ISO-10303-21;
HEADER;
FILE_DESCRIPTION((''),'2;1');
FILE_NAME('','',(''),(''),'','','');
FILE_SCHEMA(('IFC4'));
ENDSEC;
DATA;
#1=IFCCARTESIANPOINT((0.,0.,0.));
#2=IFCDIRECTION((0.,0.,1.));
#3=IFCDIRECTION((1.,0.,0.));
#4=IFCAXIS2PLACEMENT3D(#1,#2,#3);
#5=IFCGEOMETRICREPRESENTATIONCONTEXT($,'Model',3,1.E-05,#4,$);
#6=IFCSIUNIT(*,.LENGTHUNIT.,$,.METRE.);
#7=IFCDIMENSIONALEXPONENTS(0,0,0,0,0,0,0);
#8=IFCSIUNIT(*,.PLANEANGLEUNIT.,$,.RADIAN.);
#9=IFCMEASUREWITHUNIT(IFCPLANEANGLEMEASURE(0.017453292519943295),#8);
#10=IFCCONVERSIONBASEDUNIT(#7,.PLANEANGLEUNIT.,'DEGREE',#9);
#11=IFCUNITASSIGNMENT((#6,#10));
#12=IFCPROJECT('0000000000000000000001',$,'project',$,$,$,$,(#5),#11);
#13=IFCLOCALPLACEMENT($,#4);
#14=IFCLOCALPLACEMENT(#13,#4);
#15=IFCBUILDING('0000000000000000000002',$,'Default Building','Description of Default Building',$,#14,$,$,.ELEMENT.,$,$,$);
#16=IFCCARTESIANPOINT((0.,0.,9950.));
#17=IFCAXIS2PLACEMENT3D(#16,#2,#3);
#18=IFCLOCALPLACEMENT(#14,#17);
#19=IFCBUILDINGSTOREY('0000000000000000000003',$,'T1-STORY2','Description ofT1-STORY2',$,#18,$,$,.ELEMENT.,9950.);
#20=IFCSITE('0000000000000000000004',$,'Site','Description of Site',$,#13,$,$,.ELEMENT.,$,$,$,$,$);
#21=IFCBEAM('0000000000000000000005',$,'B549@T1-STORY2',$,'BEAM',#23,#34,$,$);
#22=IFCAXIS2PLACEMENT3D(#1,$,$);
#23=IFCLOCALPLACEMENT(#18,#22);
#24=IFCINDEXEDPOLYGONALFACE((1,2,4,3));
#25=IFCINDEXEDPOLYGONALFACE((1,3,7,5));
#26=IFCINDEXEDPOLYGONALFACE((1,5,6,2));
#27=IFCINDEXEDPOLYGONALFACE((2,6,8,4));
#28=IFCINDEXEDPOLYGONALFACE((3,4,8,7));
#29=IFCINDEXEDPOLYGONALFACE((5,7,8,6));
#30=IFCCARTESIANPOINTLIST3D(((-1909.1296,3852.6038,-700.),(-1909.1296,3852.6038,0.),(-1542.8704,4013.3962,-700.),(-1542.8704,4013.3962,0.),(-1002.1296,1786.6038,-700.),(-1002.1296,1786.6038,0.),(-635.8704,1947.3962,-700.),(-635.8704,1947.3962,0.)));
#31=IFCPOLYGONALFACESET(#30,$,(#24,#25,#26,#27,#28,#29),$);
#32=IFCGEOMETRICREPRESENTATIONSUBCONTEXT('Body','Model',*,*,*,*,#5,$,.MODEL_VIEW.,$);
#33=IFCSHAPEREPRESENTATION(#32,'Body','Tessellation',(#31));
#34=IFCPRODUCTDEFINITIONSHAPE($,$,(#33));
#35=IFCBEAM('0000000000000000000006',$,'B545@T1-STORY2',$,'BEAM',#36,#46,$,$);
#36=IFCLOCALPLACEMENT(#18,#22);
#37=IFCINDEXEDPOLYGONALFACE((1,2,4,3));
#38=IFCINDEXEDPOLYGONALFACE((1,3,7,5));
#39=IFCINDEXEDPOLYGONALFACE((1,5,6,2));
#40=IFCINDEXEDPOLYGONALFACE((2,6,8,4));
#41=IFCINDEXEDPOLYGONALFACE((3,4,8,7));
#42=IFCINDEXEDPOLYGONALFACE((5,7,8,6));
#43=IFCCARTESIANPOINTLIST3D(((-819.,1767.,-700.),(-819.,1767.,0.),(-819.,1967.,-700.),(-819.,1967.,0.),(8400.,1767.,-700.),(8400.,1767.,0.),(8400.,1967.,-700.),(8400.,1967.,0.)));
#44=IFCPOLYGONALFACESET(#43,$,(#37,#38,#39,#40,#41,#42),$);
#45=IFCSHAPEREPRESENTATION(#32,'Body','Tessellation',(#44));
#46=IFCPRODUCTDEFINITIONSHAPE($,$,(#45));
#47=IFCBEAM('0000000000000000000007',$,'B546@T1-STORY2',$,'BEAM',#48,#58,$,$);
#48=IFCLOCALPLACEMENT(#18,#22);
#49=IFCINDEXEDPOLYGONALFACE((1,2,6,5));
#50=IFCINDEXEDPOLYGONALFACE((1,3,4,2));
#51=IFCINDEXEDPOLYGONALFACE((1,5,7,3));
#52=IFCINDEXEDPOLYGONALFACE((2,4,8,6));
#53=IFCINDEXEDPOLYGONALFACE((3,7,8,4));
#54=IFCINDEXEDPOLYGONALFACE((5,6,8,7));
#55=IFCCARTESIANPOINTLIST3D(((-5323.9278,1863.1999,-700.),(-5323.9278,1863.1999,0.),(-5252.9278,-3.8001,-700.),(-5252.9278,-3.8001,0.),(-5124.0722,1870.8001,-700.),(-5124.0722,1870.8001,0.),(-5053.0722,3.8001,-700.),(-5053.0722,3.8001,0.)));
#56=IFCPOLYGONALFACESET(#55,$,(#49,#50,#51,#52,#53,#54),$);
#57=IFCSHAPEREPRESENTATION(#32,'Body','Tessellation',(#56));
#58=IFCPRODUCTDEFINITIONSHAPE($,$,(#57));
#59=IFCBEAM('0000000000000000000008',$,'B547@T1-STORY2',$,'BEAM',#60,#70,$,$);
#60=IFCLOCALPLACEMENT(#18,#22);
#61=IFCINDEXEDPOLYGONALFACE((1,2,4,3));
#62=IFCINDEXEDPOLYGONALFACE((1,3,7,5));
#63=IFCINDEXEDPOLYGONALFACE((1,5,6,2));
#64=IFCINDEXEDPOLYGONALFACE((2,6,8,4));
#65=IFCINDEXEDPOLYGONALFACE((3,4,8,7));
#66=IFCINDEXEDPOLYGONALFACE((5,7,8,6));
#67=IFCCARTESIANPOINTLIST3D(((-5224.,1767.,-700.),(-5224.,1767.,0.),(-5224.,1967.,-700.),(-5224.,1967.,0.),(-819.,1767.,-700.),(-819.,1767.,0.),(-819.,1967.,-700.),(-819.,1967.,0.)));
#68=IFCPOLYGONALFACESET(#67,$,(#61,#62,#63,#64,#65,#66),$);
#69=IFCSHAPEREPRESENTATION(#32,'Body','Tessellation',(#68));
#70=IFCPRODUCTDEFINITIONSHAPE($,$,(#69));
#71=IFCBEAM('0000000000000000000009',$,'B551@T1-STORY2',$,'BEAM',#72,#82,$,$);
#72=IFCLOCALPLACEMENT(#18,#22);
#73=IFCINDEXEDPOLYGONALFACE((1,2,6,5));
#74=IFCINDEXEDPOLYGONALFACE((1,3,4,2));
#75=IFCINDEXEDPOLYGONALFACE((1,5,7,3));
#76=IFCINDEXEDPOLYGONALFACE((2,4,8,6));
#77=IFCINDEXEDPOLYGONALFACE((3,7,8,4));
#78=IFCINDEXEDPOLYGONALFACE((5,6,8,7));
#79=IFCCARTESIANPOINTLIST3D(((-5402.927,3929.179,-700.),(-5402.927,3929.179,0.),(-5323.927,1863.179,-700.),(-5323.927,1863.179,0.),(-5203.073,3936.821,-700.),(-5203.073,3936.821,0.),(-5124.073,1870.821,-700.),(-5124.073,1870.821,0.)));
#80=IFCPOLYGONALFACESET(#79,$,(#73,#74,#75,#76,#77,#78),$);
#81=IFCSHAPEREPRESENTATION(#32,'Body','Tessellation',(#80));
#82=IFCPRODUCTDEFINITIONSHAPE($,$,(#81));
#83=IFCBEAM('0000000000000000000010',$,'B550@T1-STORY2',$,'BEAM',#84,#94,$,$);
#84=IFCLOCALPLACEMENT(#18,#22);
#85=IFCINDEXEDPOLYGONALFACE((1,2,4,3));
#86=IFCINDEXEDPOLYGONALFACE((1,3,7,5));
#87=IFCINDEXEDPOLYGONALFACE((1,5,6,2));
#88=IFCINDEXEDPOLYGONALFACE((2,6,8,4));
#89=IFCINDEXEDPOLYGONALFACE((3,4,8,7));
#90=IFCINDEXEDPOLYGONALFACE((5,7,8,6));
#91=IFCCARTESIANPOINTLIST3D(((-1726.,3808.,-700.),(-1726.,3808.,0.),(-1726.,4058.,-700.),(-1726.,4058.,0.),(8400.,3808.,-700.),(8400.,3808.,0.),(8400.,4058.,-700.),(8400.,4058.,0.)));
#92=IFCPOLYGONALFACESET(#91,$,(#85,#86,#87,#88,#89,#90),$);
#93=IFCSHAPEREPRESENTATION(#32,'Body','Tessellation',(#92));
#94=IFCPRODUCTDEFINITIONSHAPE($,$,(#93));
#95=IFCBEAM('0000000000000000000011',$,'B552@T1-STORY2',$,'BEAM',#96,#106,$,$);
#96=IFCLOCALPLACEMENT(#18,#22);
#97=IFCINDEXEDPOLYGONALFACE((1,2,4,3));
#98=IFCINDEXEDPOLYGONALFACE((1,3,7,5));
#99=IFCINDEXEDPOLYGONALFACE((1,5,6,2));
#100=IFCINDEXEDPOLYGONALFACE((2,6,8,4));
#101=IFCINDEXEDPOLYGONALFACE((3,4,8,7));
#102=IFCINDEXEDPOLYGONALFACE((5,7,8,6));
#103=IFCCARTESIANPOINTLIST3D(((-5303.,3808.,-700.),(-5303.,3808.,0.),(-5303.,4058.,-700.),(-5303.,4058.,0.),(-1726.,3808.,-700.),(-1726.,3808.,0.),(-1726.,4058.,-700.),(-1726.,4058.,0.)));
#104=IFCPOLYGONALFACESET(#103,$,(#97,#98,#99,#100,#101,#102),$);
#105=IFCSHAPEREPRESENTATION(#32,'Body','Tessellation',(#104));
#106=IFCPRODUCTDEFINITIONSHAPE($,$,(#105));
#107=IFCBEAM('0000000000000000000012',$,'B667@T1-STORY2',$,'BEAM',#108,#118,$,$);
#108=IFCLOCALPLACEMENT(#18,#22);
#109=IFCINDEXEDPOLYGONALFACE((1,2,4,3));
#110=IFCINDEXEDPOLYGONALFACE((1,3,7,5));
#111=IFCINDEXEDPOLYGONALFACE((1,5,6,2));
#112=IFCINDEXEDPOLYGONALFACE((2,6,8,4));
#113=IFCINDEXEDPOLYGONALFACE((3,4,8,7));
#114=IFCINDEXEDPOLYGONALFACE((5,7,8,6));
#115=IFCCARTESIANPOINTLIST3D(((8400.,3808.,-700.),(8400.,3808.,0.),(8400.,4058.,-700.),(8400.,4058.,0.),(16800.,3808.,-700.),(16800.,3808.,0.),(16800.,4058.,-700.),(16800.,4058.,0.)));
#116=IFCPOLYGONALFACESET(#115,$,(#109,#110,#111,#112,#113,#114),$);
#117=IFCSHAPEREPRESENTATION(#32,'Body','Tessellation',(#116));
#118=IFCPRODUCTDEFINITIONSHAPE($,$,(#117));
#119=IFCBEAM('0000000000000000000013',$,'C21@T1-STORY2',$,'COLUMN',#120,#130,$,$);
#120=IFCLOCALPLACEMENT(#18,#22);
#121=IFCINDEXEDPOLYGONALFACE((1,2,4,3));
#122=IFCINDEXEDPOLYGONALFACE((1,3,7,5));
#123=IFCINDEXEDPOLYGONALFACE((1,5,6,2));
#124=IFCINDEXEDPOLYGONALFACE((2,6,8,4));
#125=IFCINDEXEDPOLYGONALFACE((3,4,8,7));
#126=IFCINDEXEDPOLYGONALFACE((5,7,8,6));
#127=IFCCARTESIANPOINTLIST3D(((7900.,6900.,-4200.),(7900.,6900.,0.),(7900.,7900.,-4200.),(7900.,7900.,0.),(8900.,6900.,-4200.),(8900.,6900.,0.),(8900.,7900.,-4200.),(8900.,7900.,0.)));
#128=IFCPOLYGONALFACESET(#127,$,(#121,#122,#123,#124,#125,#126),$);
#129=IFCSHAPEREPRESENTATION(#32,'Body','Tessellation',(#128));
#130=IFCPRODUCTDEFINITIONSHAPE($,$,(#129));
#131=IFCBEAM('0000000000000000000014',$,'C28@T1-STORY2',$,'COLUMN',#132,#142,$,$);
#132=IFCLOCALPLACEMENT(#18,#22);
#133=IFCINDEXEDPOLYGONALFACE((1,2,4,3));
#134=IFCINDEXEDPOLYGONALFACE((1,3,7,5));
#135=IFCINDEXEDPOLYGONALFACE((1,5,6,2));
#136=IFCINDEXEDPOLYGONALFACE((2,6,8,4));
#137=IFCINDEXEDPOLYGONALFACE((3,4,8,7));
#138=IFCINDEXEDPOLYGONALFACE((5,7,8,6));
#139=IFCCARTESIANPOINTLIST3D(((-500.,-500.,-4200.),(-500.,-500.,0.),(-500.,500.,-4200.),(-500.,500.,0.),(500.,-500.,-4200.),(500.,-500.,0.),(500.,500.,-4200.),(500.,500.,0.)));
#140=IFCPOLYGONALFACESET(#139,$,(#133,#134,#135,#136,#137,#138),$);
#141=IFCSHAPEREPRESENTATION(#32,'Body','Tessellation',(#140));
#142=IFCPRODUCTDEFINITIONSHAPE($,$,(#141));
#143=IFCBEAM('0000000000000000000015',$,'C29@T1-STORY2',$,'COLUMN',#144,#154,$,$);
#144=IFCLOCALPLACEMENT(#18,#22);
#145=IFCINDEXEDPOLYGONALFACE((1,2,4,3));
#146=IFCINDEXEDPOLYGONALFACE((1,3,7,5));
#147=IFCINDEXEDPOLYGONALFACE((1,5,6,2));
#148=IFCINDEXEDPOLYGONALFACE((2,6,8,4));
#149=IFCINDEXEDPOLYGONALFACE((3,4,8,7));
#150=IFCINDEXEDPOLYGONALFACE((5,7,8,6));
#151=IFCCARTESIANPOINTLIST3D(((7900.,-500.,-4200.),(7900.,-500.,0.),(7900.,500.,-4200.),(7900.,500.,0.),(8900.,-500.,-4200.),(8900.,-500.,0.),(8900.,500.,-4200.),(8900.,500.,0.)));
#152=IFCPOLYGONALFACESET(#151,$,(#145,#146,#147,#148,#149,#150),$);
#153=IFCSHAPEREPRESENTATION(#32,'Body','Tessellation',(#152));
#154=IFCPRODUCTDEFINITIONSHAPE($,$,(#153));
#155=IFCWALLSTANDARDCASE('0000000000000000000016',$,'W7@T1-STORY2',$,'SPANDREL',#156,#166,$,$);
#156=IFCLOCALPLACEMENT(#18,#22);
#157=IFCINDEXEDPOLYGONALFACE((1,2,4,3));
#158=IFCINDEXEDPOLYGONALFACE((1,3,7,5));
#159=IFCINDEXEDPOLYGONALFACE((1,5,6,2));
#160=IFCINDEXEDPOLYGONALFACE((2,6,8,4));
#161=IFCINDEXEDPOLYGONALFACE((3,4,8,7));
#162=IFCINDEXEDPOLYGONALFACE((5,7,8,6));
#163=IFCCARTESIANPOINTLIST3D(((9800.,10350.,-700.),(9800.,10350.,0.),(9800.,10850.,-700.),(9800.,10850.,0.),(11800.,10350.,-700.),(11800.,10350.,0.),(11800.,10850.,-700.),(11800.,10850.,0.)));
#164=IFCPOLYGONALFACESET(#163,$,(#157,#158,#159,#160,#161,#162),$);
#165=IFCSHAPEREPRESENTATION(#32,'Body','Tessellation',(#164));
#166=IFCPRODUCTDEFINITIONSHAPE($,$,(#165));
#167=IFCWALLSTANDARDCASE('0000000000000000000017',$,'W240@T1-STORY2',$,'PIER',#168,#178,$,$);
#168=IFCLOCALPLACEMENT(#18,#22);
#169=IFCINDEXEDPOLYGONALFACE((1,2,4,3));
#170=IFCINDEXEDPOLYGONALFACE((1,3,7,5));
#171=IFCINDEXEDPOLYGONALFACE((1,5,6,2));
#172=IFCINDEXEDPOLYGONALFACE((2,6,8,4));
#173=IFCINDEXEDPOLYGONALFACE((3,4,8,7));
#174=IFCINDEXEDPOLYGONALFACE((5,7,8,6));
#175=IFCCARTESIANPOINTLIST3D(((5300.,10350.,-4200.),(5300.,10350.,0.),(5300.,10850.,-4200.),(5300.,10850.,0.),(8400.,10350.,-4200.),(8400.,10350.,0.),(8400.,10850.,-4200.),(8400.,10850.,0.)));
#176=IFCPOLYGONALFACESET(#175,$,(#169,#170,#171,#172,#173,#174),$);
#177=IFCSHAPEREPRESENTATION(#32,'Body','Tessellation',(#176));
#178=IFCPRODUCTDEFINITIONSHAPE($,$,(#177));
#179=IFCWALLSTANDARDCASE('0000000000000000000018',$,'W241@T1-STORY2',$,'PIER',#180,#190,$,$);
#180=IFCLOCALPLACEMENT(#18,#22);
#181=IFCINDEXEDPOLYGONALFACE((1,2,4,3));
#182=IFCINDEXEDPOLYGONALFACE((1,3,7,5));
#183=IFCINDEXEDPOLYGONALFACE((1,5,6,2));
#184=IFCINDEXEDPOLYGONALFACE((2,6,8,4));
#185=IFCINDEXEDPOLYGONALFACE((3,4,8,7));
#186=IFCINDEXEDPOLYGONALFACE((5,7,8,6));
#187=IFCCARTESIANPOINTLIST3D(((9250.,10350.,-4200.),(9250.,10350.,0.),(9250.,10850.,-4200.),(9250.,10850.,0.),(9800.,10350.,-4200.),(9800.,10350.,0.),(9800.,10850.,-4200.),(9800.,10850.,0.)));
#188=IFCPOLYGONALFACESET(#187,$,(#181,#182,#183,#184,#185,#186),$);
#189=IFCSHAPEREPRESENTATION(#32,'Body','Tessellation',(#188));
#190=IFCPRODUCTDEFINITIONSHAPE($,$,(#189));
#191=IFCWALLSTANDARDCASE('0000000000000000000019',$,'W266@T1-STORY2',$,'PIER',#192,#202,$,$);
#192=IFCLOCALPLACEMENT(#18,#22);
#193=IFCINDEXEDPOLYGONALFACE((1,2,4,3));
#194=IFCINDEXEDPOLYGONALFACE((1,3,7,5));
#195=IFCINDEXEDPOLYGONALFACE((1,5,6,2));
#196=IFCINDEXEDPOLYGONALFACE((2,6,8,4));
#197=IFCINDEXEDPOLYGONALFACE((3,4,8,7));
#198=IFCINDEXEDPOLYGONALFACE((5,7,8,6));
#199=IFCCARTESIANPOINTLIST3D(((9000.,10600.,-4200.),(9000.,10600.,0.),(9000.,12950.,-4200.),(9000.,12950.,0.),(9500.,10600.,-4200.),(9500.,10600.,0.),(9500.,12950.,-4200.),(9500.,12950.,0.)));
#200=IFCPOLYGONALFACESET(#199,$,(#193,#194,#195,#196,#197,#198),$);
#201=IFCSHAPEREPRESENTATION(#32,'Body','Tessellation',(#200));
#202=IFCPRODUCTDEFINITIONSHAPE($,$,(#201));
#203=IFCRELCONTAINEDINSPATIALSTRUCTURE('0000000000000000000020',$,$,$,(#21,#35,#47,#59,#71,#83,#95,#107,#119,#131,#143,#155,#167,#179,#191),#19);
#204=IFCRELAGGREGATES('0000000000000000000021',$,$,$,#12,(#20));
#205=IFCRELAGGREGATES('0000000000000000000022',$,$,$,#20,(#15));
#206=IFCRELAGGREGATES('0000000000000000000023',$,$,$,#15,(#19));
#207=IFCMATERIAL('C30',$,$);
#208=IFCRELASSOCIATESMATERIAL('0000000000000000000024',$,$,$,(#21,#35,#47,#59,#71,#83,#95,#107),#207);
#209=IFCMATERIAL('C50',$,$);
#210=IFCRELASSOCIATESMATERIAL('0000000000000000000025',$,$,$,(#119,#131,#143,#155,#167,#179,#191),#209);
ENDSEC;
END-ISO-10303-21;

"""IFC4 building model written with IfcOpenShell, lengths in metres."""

from ifc_helpers import new_model, entity, si_unit, converted_unit, frame, origin_with_axes, place, context, subcontext, project, spatial, indexed_curve, rectangle, outline, extrude, material, element, save


model = new_model("IFC4")

# Units and contexts
model_context = context("Model", 3, precision=1e-05, world=origin_with_axes())
body_context = subcontext(model_context, "Body", "Model", "MODEL_VIEW")
ifc_project = project(units=[si_unit("LENGTHUNIT", "METRE"), converted_unit("PLANEANGLEUNIT", "DEGREE", entity("IfcPlaneAngleMeasure", 0.017453292519943295), si_unit("PLANEANGLEUNIT", "RADIAN"), dimensions=[0, 0, 0, 0, 0, 0, 0])], contexts=[model_context])

# Site, building, storey
site_placement = place(None, origin_with_axes())
site = spatial("IfcSite", under=ifc_project, at=site_placement, Name="Site", Description="Description of Site", CompositionType="ELEMENT")
building_placement = place(site_placement, origin_with_axes())
building = spatial("IfcBuilding", under=site, at=building_placement, Name="Default Building", Description="Description of Default Building", CompositionType="ELEMENT")
storey_placement = place(building_placement, frame((0.0, 0.0, 9950.0), z_axis=(0.0, 0.0, 1.0), x_axis=(1.0, 0.0, 0.0)))
storey = spatial("IfcBuildingStorey", under=building, at=storey_placement, Name="T1-STORY2", Description="Description ofT1-STORY2", CompositionType="ELEMENT", Elevation=9950.0)

# Beams
ifc_material_1 = material(Name="C30")
beam_1_placement = place(storey_placement, frame((-1726.0, 3933.0, -350.0), z_axis=(0.401981, -0.915648, 0.0), x_axis=(0.915648, 0.401981, 0.0)))
element("IfcBeam", 1, at=beam_1_placement, inside=storey, material=ifc_material_1, Name="B549@T1-STORY2", ObjectType="BEAM", context=body_context, shape_type="SweptSolid", body=[
    extrude(rectangle(XDim=400.0, YDim=700.0), origin_with_axes(), (0.0, 0.0, 1.0), 2256.3256),
])
beam_2_placement = place(storey_placement, frame((-819.0, 1867.0, -350.0), z_axis=(1.0, 0.0, 0.0), x_axis=(0.0, 1.0, 0.0)))
element("IfcBeam", 2, at=beam_2_placement, inside=storey, material=ifc_material_1, Name="B545@T1-STORY2", ObjectType="BEAM", context=body_context, shape_type="SweptSolid", body=[
    extrude(rectangle(XDim=200.0, YDim=700.0), origin_with_axes(), (0.0, 0.0, 1.0), 9219.0),
])
beam_3_placement = place(storey_placement, frame((-5224.0, 1867.0, -350.0), z_axis=(0.038001, -0.999278, 0.0), x_axis=(0.999278, 0.038001, 0.0)))
element("IfcBeam", 3, at=beam_3_placement, inside=storey, material=ifc_material_1, Name="B546@T1-STORY2", ObjectType="BEAM", context=body_context, shape_type="SweptSolid", body=[
    extrude(rectangle(XDim=200.0, YDim=700.0), origin_with_axes(), (0.0, 0.0, 1.0), 1868.3495),
])
beam_4_placement = place(storey_placement, frame((-5224.0, 1867.0, -350.0), z_axis=(1.0, 0.0, 0.0), x_axis=(0.0, 1.0, 0.0)))
element("IfcBeam", 4, at=beam_4_placement, inside=storey, material=ifc_material_1, Name="B547@T1-STORY2", ObjectType="BEAM", context=body_context, shape_type="SweptSolid", body=[
    extrude(rectangle(XDim=200.0, YDim=700.0), origin_with_axes(), (0.0, 0.0, 1.0), 4405.0),
])
beam_5_placement = place(storey_placement, frame((-5303.0, 3933.0, -350.0), z_axis=(0.03821, -0.99927, 0.0), x_axis=(0.99927, 0.03821, 0.0)))
element("IfcBeam", 5, at=beam_5_placement, inside=storey, material=ifc_material_1, Name="B551@T1-STORY2", ObjectType="BEAM", context=body_context, shape_type="SweptSolid", body=[
    extrude(rectangle(XDim=200.0, YDim=700.0), origin_with_axes(), (0.0, 0.0, 1.0), 2067.5099),
])
beam_6_placement = place(storey_placement, frame((-1726.0, 3933.0, -350.0), z_axis=(1.0, 0.0, 0.0), x_axis=(0.0, 1.0, 0.0)))
element("IfcBeam", 6, at=beam_6_placement, inside=storey, material=ifc_material_1, Name="B550@T1-STORY2", ObjectType="BEAM", context=body_context, shape_type="SweptSolid", body=[
    extrude(rectangle(XDim=250.0, YDim=700.0), origin_with_axes(), (0.0, 0.0, 1.0), 10126.0),
])
beam_7_placement = place(storey_placement, frame((-5303.0, 3933.0, -350.0), z_axis=(1.0, 0.0, 0.0), x_axis=(0.0, 1.0, 0.0)))
element("IfcBeam", 7, at=beam_7_placement, inside=storey, material=ifc_material_1, Name="B552@T1-STORY2", ObjectType="BEAM", context=body_context, shape_type="SweptSolid", body=[
    extrude(rectangle(XDim=250.0, YDim=700.0), origin_with_axes(), (0.0, 0.0, 1.0), 3577.0),
])
beam_8_placement = place(storey_placement, frame((8400.0, 3933.0, -350.0), z_axis=(1.0, 0.0, 0.0), x_axis=(0.0, 1.0, 0.0)))
element("IfcBeam", 8, at=beam_8_placement, inside=storey, material=ifc_material_1, Name="B667@T1-STORY2", ObjectType="BEAM", context=body_context, shape_type="SweptSolid", body=[
    extrude(rectangle(XDim=250.0, YDim=700.0), origin_with_axes(), (0.0, 0.0, 1.0), 8400.0),
])
ifc_material_2 = material(Name="C50")
for number, where, z_axis, x_axis, name in (
    (9, (8400.0, 7400.0, -4200.0), (0.0, 0.0, 1.0), (-1.0, 0.0, 0.0), "C21@T1-STORY2"),
    (10, (0.0, 0.0, -4200.0), (0.0, 0.0, 1.0), (-1.0, 0.0, 0.0), "C28@T1-STORY2"),
    (11, (8400.0, 0.0, -4200.0), (0.0, 0.0, 1.0), (-1.0, 0.0, 0.0), "C29@T1-STORY2"),
):
    element("IfcBeam", number, at=place(storey_placement, frame(where, z_axis=z_axis, x_axis=x_axis)), inside=storey, material=ifc_material_2, Name=name, ObjectType="COLUMN", context=body_context, shape_type="SweptSolid", body=[
        extrude(rectangle(XDim=1000.0, YDim=1000.0), origin_with_axes(), (0.0, 0.0, 1.0), 4200.0),
    ])

# Walls
wall_1_placement = place(storey_placement, frame((9800.0, 10600.0, -700.0), z_axis=(0.0, 0.0, 1.0), x_axis=(1.0, 0.0, 0.0)))
element("IfcWallStandardCase", 12, at=wall_1_placement, inside=storey, material=ifc_material_2, Name="W7@T1-STORY2", ObjectType="SPANDREL", context=body_context, shape_type="SweptSolid", body=[
    extrude(outline(indexed_curve([(0.0, -250.0), (0.0, 250.0), (2000.0, 250.0), (2000.0, -250.0), (0.0, -250.0)], self_intersect=False)), origin_with_axes(), (0.0, 0.0, 1.0), 700.0),
])
wall_2_placement = place(storey_placement, frame((5300.0, 10600.0, -4200.0), z_axis=(0.0, 0.0, 1.0), x_axis=(1.0, 0.0, 0.0)))
element("IfcWallStandardCase", 13, at=wall_2_placement, inside=storey, material=ifc_material_2, Name="W240@T1-STORY2", ObjectType="PIER", context=body_context, shape_type="SweptSolid", body=[
    extrude(outline(indexed_curve([(0.0, -250.0), (0.0, 250.0), (3100.0, 250.0), (3100.0, -250.0), (0.0, -250.0)], self_intersect=False)), origin_with_axes(), (0.0, 0.0, 1.0), 4200.0),
])
wall_3_placement = place(storey_placement, frame((9250.0, 10600.0, -4200.0), z_axis=(0.0, 0.0, 1.0), x_axis=(1.0, 0.0, 0.0)))
element("IfcWallStandardCase", 14, at=wall_3_placement, inside=storey, material=ifc_material_2, Name="W241@T1-STORY2", ObjectType="PIER", context=body_context, shape_type="SweptSolid", body=[
    extrude(outline(indexed_curve([(0.0, -250.0), (0.0, 250.0), (550.0, 250.0), (550.0, -250.0), (0.0, -250.0)], self_intersect=False)), origin_with_axes(), (0.0, 0.0, 1.0), 4200.0),
])
wall_4_placement = place(storey_placement, frame((9250.0, 10600.0, -4200.0), z_axis=(0.0, 0.0, 1.0), x_axis=(0.0, 1.0, 0.0)))
element("IfcWallStandardCase", 15, at=wall_4_placement, inside=storey, material=ifc_material_2, Name="W266@T1-STORY2", ObjectType="PIER", context=body_context, shape_type="SweptSolid", body=[
    extrude(outline(indexed_curve([(0.0, -250.0), (0.0, 250.0), (2350.0, 250.0), (2350.0, -250.0), (0.0, -250.0)], self_intersect=False)), origin_with_axes(), (0.0, 0.0, 1.0), 4200.0),
])

save(model, "model.ifc")
